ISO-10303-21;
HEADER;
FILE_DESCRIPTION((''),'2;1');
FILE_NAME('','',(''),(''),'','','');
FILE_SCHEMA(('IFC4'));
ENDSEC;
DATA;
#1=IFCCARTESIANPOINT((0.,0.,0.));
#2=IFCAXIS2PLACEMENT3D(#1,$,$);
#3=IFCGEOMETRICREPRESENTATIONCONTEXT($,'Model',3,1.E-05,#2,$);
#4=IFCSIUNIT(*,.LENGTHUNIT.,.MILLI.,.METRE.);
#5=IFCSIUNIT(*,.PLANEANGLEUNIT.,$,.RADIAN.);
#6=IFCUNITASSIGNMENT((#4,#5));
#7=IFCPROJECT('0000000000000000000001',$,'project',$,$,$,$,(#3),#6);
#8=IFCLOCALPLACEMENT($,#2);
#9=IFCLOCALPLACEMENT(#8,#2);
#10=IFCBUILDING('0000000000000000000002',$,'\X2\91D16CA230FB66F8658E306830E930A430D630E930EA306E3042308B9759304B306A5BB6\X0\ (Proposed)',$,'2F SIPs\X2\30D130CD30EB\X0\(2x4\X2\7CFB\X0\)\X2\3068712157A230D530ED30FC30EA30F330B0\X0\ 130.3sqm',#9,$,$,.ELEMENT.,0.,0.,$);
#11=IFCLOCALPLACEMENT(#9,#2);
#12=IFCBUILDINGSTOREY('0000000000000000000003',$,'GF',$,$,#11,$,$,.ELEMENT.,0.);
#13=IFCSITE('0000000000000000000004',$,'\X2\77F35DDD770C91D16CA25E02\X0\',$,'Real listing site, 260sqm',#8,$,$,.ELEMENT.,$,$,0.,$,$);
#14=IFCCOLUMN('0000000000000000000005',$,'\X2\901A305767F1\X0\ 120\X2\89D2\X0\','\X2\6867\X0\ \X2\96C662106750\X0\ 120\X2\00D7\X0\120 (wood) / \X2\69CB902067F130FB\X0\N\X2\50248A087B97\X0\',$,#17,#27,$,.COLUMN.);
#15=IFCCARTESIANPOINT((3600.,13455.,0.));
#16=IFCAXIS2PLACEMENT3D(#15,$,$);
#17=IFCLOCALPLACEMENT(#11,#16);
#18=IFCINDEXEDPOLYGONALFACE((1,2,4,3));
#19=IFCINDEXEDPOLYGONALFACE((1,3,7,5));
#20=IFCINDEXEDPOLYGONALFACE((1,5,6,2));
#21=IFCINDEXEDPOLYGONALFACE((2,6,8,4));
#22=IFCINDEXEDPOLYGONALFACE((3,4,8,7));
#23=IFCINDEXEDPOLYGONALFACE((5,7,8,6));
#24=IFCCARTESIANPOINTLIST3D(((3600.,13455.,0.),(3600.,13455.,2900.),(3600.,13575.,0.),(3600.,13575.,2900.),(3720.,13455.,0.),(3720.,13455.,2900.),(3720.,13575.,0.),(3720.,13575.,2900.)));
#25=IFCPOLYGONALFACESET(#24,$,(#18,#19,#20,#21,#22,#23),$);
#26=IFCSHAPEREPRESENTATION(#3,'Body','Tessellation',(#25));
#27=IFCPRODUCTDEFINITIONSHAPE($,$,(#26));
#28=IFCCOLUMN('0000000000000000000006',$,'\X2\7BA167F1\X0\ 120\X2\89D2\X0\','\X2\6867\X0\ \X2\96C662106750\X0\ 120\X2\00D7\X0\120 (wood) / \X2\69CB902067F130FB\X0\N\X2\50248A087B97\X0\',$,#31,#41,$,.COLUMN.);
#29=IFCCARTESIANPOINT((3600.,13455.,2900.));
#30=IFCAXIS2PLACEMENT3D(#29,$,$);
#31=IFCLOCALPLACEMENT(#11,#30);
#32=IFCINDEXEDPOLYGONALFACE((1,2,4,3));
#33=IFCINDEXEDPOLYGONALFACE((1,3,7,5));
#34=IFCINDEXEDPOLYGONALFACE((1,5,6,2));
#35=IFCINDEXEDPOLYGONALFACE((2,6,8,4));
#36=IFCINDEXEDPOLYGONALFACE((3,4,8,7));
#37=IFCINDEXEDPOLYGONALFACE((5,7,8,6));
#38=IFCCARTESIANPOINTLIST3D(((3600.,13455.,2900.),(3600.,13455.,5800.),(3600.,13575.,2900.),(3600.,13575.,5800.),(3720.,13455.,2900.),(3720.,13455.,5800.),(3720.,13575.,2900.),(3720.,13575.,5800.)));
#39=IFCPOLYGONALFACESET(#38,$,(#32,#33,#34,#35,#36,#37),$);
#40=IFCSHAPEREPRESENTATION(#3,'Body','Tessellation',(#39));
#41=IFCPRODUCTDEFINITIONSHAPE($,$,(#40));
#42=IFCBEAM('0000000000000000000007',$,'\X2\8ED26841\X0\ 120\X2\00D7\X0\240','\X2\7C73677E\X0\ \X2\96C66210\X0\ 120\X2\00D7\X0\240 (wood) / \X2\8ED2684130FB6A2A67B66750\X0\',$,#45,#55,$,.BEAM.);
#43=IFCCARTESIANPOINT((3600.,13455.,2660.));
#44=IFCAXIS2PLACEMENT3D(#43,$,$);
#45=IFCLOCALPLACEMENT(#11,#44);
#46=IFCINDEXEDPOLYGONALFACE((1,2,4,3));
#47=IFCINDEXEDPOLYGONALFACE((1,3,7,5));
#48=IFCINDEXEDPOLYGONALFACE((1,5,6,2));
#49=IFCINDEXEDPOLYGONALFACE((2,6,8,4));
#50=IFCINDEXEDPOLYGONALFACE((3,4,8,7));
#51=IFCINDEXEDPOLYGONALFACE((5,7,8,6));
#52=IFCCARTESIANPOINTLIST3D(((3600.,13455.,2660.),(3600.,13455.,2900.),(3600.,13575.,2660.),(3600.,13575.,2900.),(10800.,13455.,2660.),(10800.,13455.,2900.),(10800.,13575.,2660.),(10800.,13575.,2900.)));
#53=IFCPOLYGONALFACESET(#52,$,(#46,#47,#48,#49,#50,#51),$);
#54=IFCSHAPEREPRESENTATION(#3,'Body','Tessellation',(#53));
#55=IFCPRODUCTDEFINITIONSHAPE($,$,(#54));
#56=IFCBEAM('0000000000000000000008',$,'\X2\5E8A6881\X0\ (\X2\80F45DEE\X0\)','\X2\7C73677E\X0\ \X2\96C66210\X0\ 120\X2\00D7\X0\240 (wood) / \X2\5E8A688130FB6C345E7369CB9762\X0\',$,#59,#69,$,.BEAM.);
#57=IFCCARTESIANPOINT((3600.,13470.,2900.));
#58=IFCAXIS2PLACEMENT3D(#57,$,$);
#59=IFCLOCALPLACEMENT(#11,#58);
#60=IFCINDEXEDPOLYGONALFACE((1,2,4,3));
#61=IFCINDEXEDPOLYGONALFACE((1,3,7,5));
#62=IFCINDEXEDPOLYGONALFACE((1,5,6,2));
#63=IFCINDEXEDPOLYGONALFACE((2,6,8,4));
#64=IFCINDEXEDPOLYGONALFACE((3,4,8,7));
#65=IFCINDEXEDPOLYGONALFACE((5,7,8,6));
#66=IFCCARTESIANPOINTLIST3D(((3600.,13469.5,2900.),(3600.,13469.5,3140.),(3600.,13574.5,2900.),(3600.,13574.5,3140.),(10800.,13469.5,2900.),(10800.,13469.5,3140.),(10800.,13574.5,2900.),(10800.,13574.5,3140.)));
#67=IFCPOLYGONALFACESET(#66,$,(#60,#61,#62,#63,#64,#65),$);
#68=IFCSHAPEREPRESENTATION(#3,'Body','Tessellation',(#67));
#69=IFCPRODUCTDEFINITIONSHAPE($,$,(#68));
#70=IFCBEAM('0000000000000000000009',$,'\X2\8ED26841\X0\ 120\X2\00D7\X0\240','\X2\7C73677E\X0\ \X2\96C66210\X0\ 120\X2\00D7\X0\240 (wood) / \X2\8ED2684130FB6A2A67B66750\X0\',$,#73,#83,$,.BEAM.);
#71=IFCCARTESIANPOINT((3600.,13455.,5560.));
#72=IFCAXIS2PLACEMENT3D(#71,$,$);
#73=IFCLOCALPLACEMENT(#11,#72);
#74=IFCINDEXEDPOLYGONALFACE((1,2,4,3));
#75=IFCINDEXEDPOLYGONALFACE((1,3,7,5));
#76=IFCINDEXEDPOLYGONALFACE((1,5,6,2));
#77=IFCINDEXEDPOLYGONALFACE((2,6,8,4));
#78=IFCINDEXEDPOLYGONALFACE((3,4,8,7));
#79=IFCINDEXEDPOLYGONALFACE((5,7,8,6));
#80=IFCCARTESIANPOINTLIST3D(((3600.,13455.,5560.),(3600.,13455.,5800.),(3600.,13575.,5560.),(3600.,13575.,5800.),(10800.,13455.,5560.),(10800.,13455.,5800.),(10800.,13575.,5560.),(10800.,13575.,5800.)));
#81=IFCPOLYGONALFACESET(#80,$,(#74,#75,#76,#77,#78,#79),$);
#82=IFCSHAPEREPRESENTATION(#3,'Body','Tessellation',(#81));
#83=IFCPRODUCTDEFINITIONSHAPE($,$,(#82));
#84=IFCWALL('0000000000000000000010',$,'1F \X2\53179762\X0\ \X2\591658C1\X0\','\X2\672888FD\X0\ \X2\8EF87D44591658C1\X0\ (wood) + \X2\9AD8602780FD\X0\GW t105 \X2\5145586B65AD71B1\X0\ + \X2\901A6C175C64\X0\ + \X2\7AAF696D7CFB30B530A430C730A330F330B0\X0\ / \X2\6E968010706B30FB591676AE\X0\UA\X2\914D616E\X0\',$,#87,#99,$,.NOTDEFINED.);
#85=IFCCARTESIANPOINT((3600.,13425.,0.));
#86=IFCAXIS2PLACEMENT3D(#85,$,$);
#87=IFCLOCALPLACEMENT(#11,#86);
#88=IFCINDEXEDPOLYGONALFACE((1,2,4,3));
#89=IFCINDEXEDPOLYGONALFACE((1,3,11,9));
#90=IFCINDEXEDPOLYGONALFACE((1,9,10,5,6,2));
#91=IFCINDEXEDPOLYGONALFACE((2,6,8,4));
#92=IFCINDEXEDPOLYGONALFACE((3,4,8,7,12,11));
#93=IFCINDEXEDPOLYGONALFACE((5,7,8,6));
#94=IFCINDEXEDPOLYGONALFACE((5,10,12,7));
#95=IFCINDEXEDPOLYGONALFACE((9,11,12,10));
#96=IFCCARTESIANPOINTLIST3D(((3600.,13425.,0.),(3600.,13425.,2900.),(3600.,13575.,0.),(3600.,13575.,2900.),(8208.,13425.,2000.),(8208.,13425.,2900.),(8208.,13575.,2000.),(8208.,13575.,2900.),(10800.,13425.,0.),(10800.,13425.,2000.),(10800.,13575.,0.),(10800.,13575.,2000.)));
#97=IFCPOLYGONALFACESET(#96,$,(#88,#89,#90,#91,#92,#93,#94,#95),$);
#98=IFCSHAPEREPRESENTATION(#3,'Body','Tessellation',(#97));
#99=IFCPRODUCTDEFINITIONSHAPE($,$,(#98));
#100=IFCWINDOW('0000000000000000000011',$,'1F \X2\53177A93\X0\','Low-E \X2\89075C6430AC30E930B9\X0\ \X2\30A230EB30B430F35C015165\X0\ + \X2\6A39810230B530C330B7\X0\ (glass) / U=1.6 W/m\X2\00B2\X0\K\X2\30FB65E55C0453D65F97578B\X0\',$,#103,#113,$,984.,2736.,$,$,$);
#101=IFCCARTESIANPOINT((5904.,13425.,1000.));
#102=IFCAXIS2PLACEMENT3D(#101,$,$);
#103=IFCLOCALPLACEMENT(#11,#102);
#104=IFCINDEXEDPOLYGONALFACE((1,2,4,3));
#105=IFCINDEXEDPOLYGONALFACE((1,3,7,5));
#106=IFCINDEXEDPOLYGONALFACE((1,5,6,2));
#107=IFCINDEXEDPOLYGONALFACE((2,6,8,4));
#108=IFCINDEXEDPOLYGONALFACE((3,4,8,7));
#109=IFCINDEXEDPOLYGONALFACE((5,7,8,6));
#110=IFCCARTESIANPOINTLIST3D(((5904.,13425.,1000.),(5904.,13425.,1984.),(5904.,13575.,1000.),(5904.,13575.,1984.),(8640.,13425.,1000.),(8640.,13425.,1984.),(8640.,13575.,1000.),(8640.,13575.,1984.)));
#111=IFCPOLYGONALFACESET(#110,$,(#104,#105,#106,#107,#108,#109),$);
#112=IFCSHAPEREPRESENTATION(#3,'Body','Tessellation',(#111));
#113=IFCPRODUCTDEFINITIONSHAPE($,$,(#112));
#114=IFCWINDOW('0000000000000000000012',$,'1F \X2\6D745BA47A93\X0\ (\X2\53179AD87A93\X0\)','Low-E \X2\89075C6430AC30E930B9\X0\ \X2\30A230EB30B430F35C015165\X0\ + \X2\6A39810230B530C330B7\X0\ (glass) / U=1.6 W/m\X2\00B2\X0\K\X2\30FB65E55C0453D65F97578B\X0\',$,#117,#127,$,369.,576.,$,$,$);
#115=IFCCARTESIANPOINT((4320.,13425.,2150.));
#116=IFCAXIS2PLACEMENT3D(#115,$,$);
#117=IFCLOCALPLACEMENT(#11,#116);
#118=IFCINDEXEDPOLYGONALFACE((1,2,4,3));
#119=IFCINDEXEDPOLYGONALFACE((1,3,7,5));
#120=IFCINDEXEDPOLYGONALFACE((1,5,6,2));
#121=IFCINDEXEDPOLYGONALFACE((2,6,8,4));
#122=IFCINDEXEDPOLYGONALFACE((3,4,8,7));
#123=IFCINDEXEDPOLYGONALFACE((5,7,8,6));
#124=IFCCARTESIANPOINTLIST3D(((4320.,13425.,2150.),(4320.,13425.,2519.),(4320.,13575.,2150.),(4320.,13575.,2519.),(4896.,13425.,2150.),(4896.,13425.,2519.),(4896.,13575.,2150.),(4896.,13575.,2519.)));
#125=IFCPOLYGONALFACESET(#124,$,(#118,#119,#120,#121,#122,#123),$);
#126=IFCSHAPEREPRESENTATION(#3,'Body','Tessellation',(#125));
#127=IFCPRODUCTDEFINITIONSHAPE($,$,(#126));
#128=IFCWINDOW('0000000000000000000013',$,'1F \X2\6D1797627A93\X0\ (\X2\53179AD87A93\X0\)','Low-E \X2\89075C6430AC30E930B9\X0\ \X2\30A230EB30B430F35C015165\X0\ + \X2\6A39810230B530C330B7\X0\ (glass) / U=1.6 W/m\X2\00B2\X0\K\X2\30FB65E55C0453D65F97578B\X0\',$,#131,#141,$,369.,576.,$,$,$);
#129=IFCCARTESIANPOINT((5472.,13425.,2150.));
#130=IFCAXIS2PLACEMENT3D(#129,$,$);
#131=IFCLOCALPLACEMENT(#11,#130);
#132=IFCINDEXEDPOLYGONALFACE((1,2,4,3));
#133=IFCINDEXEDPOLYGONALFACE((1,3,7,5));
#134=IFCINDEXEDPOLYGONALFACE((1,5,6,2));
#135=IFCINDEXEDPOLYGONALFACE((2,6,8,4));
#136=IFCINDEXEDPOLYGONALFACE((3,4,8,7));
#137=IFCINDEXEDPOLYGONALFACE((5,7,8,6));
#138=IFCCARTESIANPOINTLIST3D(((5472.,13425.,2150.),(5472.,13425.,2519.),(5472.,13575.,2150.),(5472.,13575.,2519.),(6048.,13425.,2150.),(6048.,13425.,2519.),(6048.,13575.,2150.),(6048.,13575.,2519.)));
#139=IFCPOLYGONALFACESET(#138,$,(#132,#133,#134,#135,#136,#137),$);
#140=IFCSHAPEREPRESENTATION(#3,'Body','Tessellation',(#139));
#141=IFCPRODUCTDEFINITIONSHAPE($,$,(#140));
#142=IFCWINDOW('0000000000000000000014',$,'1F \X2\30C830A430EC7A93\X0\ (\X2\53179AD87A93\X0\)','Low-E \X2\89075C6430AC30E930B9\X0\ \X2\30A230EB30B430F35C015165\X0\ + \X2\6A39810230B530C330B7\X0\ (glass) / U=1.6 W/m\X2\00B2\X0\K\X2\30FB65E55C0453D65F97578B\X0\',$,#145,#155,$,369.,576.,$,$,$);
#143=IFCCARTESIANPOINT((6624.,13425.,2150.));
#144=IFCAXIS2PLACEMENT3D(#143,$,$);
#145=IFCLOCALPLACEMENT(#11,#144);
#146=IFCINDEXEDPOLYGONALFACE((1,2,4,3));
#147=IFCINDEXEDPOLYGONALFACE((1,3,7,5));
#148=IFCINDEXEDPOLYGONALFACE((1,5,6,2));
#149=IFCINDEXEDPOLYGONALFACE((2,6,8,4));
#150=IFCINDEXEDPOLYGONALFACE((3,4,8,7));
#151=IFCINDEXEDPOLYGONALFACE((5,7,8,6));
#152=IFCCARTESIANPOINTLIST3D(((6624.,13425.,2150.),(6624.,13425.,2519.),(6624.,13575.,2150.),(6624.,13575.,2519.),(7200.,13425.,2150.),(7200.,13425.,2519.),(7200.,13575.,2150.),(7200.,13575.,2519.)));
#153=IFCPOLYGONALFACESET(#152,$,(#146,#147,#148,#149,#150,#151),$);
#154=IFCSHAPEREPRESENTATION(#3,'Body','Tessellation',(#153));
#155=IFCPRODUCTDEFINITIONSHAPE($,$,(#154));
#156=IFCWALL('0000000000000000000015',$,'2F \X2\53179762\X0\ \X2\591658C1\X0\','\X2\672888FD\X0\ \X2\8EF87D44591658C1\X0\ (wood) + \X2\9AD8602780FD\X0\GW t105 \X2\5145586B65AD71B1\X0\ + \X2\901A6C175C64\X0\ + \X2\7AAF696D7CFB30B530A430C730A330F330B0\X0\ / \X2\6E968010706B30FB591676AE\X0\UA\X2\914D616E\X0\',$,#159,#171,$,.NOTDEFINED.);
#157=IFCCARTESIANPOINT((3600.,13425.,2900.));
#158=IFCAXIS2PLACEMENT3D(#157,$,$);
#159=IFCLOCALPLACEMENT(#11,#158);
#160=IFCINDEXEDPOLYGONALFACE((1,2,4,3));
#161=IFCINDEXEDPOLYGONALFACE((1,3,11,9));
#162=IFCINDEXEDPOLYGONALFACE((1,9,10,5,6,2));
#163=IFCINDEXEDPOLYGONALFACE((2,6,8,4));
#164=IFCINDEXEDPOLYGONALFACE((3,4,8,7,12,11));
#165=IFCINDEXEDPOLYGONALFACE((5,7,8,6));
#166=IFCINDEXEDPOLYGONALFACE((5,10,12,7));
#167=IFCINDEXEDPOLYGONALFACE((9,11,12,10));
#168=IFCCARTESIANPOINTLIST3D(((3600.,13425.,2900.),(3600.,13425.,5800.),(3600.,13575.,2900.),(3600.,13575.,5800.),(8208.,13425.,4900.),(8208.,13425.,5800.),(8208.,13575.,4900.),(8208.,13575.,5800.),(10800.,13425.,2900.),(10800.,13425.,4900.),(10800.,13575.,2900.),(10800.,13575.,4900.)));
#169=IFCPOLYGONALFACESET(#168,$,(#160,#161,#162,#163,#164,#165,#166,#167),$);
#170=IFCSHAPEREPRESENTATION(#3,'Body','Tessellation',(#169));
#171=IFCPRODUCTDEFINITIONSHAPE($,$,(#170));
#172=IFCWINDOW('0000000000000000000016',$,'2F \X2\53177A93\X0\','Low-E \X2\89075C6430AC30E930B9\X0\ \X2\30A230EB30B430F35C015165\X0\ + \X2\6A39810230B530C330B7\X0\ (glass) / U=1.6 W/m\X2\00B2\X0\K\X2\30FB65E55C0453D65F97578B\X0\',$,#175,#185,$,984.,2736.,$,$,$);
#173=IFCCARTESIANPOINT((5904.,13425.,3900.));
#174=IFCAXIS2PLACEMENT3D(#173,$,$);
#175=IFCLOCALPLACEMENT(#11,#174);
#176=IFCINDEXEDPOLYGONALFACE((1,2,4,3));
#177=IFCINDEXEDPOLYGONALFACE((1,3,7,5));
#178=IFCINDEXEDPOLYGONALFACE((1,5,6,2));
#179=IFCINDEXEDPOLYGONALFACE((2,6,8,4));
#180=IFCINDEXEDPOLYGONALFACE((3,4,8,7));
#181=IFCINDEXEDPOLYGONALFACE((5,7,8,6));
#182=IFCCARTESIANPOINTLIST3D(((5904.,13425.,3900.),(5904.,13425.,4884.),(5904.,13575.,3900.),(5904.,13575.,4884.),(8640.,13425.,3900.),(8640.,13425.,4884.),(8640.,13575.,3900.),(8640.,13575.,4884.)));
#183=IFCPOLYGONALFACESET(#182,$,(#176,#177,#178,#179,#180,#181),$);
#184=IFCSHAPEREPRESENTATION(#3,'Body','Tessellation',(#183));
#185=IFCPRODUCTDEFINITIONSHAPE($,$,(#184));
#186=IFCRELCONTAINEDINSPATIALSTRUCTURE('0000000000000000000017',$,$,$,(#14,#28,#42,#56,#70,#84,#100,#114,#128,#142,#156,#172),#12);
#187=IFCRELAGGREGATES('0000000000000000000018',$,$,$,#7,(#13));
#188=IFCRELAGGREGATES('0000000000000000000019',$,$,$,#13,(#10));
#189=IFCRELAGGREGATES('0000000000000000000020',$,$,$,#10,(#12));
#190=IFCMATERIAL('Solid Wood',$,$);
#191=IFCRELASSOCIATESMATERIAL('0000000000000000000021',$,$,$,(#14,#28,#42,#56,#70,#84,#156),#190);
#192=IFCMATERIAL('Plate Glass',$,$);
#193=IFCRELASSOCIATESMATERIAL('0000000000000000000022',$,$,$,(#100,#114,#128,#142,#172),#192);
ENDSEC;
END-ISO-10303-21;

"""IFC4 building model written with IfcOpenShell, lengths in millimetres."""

from ifc_helpers import new_model, si_unit, frame, frame_2d, origin, place, context, project, spatial, rectangle, extrude, material, element, fill, save


model = new_model("IFC4")

# Units and contexts
model_context = context("Model", 3, precision=1e-05, world=origin())
ifc_project = project(units=[si_unit("LENGTHUNIT", "METRE", prefix="MILLI"), si_unit("PLANEANGLEUNIT", "RADIAN")], contexts=[model_context])

# Site, building, storey
site_placement = place(None, origin())
site = spatial("IfcSite", under=ifc_project, at=site_placement, Name="石川県金沢市", ObjectType="Real listing site, 260sqm", CompositionType="ELEMENT", RefElevation=0.0)
building_placement = place(site_placement, origin())
building = spatial("IfcBuilding", under=site, at=building_placement, Name="金沢・書斎とライブラリのある静かな家 (Proposed)", ObjectType="2F SIPsパネル(2x4系)と無垢フローリング 130.3sqm", CompositionType="ELEMENT", ElevationOfRefHeight=0.0, ElevationOfTerrain=0.0)
storey_placement = place(building_placement, origin())
storey = spatial("IfcBuildingStorey", under=building, at=storey_placement, Name="GF", CompositionType="ELEMENT", Elevation=0.0)

# Columns
ifc_material_1 = material(Name="Solid Wood")
column_1_placement = place(storey_placement, frame((3600.0, 13455.0, 0.0)))
element("IfcColumn", 1, at=column_1_placement, inside=storey, material=ifc_material_1, Name="通し柱 120角", Description="桧 集成材 120×120 (wood) / 構造柱・N値計算", PredefinedType="COLUMN", context=model_context, shape_type="SweptSolid", body=[
    extrude(rectangle(XDim=120.0, YDim=120.0, at=frame_2d((60.0, 60.0))), frame((3600.0, 13455.0, 0.0)), (0.0, 0.0, 1.0), 2900.0),
])
column_2_placement = place(storey_placement, frame((3600.0, 13455.0, 2900.0)))
element("IfcColumn", 2, at=column_2_placement, inside=storey, material=ifc_material_1, Name="管柱 120角", Description="桧 集成材 120×120 (wood) / 構造柱・N値計算", PredefinedType="COLUMN", context=model_context, shape_type="SweptSolid", body=[
    extrude(rectangle(XDim=120.0, YDim=120.0, at=frame_2d((60.0, 60.0))), frame((3600.0, 13455.0, 2900.0)), (0.0, 0.0, 1.0), 2900.0),
])

# Beams
beam_1_placement = place(storey_placement, frame((3600.0, 13455.0, 2660.0)))
element("IfcBeam", 3, at=beam_1_placement, inside=storey, material=ifc_material_1, Name="軒桁 120×240", Description="米松 集成 120×240 (wood) / 軒桁・横架材", PredefinedType="BEAM", context=model_context, shape_type="SweptSolid", body=[
    extrude(rectangle(XDim=7200.0, YDim=120.0, at=frame_2d((3600.0, 60.0))), frame((3600.0, 13455.0, 2660.0)), (0.0, 0.0, 1.0), 240.0),
])
beam_2_placement = place(storey_placement, frame((3600.0, 13470.0, 2900.0)))
element("IfcBeam", 4, at=beam_2_placement, inside=storey, material=ifc_material_1, Name="床梁 (胴差)", Description="米松 集成 120×240 (wood) / 床梁・水平構面", PredefinedType="BEAM", context=model_context, shape_type="SweptSolid", body=[
    extrude(rectangle(XDim=7200.0, YDim=105.0, at=frame_2d((3600.0, 52.0))), frame((3600.0, 13470.0, 2900.0)), (0.0, 0.0, 1.0), 240.0),
])
beam_3_placement = place(storey_placement, frame((3600.0, 13455.0, 5560.0)))
element("IfcBeam", 5, at=beam_3_placement, inside=storey, material=ifc_material_1, Name="軒桁 120×240", Description="米松 集成 120×240 (wood) / 軒桁・横架材", PredefinedType="BEAM", context=model_context, shape_type="SweptSolid", body=[
    extrude(rectangle(XDim=7200.0, YDim=120.0, at=frame_2d((3600.0, 60.0))), frame((3600.0, 13455.0, 5560.0)), (0.0, 0.0, 1.0), 240.0),
])

# Wall, openings, windows
wall_1_placement = place(storey_placement, frame((3600.0, 13425.0, 0.0)))
wall_1 = element("IfcWall", 6, at=wall_1_placement, inside=storey, material=ifc_material_1, Name="1F 北面 外壁", Description="木製 軸組外壁 (wood) + 高性能GW t105 充填断熱 + 通気層 + 窯業系サイディング / 準耐火・外皮UA配慮", PredefinedType="NOTDEFINED", context=model_context, shape_type="SweptSolid", body=[
    extrude(rectangle(XDim=7200.0, YDim=150.0, at=frame_2d((3600.0, 75.0))), frame((3600.0, 13425.0, 0.0)), (0.0, 0.0, 1.0), 2900.0),
])
opening_1_placement = place(storey_placement, frame((5904.0, 13425.0, 1000.0)))
opening_1 = element("IfcOpeningElement", 7, at=opening_1_placement, cuts=wall_1, PredefinedType="NOTDEFINED", context=model_context, shape_type="SweptSolid", body=[
    extrude(rectangle(XDim=2736.0, YDim=150.0, at=frame_2d((1368.0, 75.0))), frame((5904.0, 13425.0, 1000.0)), (0.0, 0.0, 1.0), 984.0),
])
opening_2_placement = place(storey_placement, frame((4320.0, 13425.0, 2150.0)))
opening_2 = element("IfcOpeningElement", 8, at=opening_2_placement, cuts=wall_1, PredefinedType="NOTDEFINED", context=model_context, shape_type="SweptSolid", body=[
    extrude(rectangle(XDim=576.0, YDim=150.0, at=frame_2d((288.0, 75.0))), frame((4320.0, 13425.0, 2150.0)), (0.0, 0.0, 1.0), 369.0),
])
opening_3_placement = place(storey_placement, frame((5472.0, 13425.0, 2150.0)))
opening_3 = element("IfcOpeningElement", 9, at=opening_3_placement, cuts=wall_1, PredefinedType="NOTDEFINED", context=model_context, shape_type="SweptSolid", body=[
    extrude(rectangle(XDim=576.0, YDim=150.0, at=frame_2d((288.0, 75.0))), frame((5472.0, 13425.0, 2150.0)), (0.0, 0.0, 1.0), 369.0),
])
opening_4_placement = place(storey_placement, frame((6624.0, 13425.0, 2150.0)))
opening_4 = element("IfcOpeningElement", 10, at=opening_4_placement, cuts=wall_1, PredefinedType="NOTDEFINED", context=model_context, shape_type="SweptSolid", body=[
    extrude(rectangle(XDim=576.0, YDim=150.0, at=frame_2d((288.0, 75.0))), frame((6624.0, 13425.0, 2150.0)), (0.0, 0.0, 1.0), 369.0),
])
ifc_material_2 = material(Name="Plate Glass")
window_1_placement = place(storey_placement, frame((5904.0, 13425.0, 1000.0)))
window_1 = element("IfcWindow", 11, at=window_1_placement, inside=storey, material=ifc_material_2, Name="1F 北窓", Description="Low-E 複層ガラス アルゴン封入 + 樹脂サッシ (glass) / U=1.6 W/m²K・日射取得型", OverallHeight=984.0, OverallWidth=2736.0, context=model_context, shape_type="SweptSolid", body=[
    extrude(rectangle(XDim=2736.0, YDim=150.0, at=frame_2d((1368.0, 75.0))), frame((5904.0, 13425.0, 1000.0)), (0.0, 0.0, 1.0), 984.0),
])
fill(opening_1, window_1)
window_2_placement = place(storey_placement, frame((4320.0, 13425.0, 2150.0)))
window_2 = element("IfcWindow", 12, at=window_2_placement, inside=storey, material=ifc_material_2, Name="1F 浴室窓 (北高窓)", Description="Low-E 複層ガラス アルゴン封入 + 樹脂サッシ (glass) / U=1.6 W/m²K・日射取得型", OverallHeight=369.0, OverallWidth=576.0, context=model_context, shape_type="SweptSolid", body=[
    extrude(rectangle(XDim=576.0, YDim=150.0, at=frame_2d((288.0, 75.0))), frame((4320.0, 13425.0, 2150.0)), (0.0, 0.0, 1.0), 369.0),
])
fill(opening_2, window_2)
window_3_placement = place(storey_placement, frame((5472.0, 13425.0, 2150.0)))
window_3 = element("IfcWindow", 13, at=window_3_placement, inside=storey, material=ifc_material_2, Name="1F 洗面窓 (北高窓)", Description="Low-E 複層ガラス アルゴン封入 + 樹脂サッシ (glass) / U=1.6 W/m²K・日射取得型", OverallHeight=369.0, OverallWidth=576.0, context=model_context, shape_type="SweptSolid", body=[
    extrude(rectangle(XDim=576.0, YDim=150.0, at=frame_2d((288.0, 75.0))), frame((5472.0, 13425.0, 2150.0)), (0.0, 0.0, 1.0), 369.0),
])
fill(opening_3, window_3)
window_4_placement = place(storey_placement, frame((6624.0, 13425.0, 2150.0)))
window_4 = element("IfcWindow", 14, at=window_4_placement, inside=storey, material=ifc_material_2, Name="1F トイレ窓 (北高窓)", Description="Low-E 複層ガラス アルゴン封入 + 樹脂サッシ (glass) / U=1.6 W/m²K・日射取得型", OverallHeight=369.0, OverallWidth=576.0, context=model_context, shape_type="SweptSolid", body=[
    extrude(rectangle(XDim=576.0, YDim=150.0, at=frame_2d((288.0, 75.0))), frame((6624.0, 13425.0, 2150.0)), (0.0, 0.0, 1.0), 369.0),
])
fill(opening_4, window_4)

# Wall, opening, window
wall_2_placement = place(storey_placement, frame((3600.0, 13425.0, 2900.0)))
wall_2 = element("IfcWall", 15, at=wall_2_placement, inside=storey, material=ifc_material_1, Name="2F 北面 外壁", Description="木製 軸組外壁 (wood) + 高性能GW t105 充填断熱 + 通気層 + 窯業系サイディング / 準耐火・外皮UA配慮", PredefinedType="NOTDEFINED", context=model_context, shape_type="SweptSolid", body=[
    extrude(rectangle(XDim=7200.0, YDim=150.0, at=frame_2d((3600.0, 75.0))), frame((3600.0, 13425.0, 2900.0)), (0.0, 0.0, 1.0), 2900.0),
])
opening_5_placement = place(storey_placement, frame((5904.0, 13425.0, 3900.0)))
opening_5 = element("IfcOpeningElement", 16, at=opening_5_placement, cuts=wall_2, PredefinedType="NOTDEFINED", context=model_context, shape_type="SweptSolid", body=[
    extrude(rectangle(XDim=2736.0, YDim=150.0, at=frame_2d((1368.0, 75.0))), frame((5904.0, 13425.0, 3900.0)), (0.0, 0.0, 1.0), 984.0),
])
window_5_placement = place(storey_placement, frame((5904.0, 13425.0, 3900.0)))
window_5 = element("IfcWindow", 17, at=window_5_placement, inside=storey, material=ifc_material_2, Name="2F 北窓", Description="Low-E 複層ガラス アルゴン封入 + 樹脂サッシ (glass) / U=1.6 W/m²K・日射取得型", OverallHeight=984.0, OverallWidth=2736.0, context=model_context, shape_type="SweptSolid", body=[
    extrude(rectangle(XDim=2736.0, YDim=150.0, at=frame_2d((1368.0, 75.0))), frame((5904.0, 13425.0, 3900.0)), (0.0, 0.0, 1.0), 984.0),
])
fill(opening_5, window_5)

save(model, "model.ifc")
